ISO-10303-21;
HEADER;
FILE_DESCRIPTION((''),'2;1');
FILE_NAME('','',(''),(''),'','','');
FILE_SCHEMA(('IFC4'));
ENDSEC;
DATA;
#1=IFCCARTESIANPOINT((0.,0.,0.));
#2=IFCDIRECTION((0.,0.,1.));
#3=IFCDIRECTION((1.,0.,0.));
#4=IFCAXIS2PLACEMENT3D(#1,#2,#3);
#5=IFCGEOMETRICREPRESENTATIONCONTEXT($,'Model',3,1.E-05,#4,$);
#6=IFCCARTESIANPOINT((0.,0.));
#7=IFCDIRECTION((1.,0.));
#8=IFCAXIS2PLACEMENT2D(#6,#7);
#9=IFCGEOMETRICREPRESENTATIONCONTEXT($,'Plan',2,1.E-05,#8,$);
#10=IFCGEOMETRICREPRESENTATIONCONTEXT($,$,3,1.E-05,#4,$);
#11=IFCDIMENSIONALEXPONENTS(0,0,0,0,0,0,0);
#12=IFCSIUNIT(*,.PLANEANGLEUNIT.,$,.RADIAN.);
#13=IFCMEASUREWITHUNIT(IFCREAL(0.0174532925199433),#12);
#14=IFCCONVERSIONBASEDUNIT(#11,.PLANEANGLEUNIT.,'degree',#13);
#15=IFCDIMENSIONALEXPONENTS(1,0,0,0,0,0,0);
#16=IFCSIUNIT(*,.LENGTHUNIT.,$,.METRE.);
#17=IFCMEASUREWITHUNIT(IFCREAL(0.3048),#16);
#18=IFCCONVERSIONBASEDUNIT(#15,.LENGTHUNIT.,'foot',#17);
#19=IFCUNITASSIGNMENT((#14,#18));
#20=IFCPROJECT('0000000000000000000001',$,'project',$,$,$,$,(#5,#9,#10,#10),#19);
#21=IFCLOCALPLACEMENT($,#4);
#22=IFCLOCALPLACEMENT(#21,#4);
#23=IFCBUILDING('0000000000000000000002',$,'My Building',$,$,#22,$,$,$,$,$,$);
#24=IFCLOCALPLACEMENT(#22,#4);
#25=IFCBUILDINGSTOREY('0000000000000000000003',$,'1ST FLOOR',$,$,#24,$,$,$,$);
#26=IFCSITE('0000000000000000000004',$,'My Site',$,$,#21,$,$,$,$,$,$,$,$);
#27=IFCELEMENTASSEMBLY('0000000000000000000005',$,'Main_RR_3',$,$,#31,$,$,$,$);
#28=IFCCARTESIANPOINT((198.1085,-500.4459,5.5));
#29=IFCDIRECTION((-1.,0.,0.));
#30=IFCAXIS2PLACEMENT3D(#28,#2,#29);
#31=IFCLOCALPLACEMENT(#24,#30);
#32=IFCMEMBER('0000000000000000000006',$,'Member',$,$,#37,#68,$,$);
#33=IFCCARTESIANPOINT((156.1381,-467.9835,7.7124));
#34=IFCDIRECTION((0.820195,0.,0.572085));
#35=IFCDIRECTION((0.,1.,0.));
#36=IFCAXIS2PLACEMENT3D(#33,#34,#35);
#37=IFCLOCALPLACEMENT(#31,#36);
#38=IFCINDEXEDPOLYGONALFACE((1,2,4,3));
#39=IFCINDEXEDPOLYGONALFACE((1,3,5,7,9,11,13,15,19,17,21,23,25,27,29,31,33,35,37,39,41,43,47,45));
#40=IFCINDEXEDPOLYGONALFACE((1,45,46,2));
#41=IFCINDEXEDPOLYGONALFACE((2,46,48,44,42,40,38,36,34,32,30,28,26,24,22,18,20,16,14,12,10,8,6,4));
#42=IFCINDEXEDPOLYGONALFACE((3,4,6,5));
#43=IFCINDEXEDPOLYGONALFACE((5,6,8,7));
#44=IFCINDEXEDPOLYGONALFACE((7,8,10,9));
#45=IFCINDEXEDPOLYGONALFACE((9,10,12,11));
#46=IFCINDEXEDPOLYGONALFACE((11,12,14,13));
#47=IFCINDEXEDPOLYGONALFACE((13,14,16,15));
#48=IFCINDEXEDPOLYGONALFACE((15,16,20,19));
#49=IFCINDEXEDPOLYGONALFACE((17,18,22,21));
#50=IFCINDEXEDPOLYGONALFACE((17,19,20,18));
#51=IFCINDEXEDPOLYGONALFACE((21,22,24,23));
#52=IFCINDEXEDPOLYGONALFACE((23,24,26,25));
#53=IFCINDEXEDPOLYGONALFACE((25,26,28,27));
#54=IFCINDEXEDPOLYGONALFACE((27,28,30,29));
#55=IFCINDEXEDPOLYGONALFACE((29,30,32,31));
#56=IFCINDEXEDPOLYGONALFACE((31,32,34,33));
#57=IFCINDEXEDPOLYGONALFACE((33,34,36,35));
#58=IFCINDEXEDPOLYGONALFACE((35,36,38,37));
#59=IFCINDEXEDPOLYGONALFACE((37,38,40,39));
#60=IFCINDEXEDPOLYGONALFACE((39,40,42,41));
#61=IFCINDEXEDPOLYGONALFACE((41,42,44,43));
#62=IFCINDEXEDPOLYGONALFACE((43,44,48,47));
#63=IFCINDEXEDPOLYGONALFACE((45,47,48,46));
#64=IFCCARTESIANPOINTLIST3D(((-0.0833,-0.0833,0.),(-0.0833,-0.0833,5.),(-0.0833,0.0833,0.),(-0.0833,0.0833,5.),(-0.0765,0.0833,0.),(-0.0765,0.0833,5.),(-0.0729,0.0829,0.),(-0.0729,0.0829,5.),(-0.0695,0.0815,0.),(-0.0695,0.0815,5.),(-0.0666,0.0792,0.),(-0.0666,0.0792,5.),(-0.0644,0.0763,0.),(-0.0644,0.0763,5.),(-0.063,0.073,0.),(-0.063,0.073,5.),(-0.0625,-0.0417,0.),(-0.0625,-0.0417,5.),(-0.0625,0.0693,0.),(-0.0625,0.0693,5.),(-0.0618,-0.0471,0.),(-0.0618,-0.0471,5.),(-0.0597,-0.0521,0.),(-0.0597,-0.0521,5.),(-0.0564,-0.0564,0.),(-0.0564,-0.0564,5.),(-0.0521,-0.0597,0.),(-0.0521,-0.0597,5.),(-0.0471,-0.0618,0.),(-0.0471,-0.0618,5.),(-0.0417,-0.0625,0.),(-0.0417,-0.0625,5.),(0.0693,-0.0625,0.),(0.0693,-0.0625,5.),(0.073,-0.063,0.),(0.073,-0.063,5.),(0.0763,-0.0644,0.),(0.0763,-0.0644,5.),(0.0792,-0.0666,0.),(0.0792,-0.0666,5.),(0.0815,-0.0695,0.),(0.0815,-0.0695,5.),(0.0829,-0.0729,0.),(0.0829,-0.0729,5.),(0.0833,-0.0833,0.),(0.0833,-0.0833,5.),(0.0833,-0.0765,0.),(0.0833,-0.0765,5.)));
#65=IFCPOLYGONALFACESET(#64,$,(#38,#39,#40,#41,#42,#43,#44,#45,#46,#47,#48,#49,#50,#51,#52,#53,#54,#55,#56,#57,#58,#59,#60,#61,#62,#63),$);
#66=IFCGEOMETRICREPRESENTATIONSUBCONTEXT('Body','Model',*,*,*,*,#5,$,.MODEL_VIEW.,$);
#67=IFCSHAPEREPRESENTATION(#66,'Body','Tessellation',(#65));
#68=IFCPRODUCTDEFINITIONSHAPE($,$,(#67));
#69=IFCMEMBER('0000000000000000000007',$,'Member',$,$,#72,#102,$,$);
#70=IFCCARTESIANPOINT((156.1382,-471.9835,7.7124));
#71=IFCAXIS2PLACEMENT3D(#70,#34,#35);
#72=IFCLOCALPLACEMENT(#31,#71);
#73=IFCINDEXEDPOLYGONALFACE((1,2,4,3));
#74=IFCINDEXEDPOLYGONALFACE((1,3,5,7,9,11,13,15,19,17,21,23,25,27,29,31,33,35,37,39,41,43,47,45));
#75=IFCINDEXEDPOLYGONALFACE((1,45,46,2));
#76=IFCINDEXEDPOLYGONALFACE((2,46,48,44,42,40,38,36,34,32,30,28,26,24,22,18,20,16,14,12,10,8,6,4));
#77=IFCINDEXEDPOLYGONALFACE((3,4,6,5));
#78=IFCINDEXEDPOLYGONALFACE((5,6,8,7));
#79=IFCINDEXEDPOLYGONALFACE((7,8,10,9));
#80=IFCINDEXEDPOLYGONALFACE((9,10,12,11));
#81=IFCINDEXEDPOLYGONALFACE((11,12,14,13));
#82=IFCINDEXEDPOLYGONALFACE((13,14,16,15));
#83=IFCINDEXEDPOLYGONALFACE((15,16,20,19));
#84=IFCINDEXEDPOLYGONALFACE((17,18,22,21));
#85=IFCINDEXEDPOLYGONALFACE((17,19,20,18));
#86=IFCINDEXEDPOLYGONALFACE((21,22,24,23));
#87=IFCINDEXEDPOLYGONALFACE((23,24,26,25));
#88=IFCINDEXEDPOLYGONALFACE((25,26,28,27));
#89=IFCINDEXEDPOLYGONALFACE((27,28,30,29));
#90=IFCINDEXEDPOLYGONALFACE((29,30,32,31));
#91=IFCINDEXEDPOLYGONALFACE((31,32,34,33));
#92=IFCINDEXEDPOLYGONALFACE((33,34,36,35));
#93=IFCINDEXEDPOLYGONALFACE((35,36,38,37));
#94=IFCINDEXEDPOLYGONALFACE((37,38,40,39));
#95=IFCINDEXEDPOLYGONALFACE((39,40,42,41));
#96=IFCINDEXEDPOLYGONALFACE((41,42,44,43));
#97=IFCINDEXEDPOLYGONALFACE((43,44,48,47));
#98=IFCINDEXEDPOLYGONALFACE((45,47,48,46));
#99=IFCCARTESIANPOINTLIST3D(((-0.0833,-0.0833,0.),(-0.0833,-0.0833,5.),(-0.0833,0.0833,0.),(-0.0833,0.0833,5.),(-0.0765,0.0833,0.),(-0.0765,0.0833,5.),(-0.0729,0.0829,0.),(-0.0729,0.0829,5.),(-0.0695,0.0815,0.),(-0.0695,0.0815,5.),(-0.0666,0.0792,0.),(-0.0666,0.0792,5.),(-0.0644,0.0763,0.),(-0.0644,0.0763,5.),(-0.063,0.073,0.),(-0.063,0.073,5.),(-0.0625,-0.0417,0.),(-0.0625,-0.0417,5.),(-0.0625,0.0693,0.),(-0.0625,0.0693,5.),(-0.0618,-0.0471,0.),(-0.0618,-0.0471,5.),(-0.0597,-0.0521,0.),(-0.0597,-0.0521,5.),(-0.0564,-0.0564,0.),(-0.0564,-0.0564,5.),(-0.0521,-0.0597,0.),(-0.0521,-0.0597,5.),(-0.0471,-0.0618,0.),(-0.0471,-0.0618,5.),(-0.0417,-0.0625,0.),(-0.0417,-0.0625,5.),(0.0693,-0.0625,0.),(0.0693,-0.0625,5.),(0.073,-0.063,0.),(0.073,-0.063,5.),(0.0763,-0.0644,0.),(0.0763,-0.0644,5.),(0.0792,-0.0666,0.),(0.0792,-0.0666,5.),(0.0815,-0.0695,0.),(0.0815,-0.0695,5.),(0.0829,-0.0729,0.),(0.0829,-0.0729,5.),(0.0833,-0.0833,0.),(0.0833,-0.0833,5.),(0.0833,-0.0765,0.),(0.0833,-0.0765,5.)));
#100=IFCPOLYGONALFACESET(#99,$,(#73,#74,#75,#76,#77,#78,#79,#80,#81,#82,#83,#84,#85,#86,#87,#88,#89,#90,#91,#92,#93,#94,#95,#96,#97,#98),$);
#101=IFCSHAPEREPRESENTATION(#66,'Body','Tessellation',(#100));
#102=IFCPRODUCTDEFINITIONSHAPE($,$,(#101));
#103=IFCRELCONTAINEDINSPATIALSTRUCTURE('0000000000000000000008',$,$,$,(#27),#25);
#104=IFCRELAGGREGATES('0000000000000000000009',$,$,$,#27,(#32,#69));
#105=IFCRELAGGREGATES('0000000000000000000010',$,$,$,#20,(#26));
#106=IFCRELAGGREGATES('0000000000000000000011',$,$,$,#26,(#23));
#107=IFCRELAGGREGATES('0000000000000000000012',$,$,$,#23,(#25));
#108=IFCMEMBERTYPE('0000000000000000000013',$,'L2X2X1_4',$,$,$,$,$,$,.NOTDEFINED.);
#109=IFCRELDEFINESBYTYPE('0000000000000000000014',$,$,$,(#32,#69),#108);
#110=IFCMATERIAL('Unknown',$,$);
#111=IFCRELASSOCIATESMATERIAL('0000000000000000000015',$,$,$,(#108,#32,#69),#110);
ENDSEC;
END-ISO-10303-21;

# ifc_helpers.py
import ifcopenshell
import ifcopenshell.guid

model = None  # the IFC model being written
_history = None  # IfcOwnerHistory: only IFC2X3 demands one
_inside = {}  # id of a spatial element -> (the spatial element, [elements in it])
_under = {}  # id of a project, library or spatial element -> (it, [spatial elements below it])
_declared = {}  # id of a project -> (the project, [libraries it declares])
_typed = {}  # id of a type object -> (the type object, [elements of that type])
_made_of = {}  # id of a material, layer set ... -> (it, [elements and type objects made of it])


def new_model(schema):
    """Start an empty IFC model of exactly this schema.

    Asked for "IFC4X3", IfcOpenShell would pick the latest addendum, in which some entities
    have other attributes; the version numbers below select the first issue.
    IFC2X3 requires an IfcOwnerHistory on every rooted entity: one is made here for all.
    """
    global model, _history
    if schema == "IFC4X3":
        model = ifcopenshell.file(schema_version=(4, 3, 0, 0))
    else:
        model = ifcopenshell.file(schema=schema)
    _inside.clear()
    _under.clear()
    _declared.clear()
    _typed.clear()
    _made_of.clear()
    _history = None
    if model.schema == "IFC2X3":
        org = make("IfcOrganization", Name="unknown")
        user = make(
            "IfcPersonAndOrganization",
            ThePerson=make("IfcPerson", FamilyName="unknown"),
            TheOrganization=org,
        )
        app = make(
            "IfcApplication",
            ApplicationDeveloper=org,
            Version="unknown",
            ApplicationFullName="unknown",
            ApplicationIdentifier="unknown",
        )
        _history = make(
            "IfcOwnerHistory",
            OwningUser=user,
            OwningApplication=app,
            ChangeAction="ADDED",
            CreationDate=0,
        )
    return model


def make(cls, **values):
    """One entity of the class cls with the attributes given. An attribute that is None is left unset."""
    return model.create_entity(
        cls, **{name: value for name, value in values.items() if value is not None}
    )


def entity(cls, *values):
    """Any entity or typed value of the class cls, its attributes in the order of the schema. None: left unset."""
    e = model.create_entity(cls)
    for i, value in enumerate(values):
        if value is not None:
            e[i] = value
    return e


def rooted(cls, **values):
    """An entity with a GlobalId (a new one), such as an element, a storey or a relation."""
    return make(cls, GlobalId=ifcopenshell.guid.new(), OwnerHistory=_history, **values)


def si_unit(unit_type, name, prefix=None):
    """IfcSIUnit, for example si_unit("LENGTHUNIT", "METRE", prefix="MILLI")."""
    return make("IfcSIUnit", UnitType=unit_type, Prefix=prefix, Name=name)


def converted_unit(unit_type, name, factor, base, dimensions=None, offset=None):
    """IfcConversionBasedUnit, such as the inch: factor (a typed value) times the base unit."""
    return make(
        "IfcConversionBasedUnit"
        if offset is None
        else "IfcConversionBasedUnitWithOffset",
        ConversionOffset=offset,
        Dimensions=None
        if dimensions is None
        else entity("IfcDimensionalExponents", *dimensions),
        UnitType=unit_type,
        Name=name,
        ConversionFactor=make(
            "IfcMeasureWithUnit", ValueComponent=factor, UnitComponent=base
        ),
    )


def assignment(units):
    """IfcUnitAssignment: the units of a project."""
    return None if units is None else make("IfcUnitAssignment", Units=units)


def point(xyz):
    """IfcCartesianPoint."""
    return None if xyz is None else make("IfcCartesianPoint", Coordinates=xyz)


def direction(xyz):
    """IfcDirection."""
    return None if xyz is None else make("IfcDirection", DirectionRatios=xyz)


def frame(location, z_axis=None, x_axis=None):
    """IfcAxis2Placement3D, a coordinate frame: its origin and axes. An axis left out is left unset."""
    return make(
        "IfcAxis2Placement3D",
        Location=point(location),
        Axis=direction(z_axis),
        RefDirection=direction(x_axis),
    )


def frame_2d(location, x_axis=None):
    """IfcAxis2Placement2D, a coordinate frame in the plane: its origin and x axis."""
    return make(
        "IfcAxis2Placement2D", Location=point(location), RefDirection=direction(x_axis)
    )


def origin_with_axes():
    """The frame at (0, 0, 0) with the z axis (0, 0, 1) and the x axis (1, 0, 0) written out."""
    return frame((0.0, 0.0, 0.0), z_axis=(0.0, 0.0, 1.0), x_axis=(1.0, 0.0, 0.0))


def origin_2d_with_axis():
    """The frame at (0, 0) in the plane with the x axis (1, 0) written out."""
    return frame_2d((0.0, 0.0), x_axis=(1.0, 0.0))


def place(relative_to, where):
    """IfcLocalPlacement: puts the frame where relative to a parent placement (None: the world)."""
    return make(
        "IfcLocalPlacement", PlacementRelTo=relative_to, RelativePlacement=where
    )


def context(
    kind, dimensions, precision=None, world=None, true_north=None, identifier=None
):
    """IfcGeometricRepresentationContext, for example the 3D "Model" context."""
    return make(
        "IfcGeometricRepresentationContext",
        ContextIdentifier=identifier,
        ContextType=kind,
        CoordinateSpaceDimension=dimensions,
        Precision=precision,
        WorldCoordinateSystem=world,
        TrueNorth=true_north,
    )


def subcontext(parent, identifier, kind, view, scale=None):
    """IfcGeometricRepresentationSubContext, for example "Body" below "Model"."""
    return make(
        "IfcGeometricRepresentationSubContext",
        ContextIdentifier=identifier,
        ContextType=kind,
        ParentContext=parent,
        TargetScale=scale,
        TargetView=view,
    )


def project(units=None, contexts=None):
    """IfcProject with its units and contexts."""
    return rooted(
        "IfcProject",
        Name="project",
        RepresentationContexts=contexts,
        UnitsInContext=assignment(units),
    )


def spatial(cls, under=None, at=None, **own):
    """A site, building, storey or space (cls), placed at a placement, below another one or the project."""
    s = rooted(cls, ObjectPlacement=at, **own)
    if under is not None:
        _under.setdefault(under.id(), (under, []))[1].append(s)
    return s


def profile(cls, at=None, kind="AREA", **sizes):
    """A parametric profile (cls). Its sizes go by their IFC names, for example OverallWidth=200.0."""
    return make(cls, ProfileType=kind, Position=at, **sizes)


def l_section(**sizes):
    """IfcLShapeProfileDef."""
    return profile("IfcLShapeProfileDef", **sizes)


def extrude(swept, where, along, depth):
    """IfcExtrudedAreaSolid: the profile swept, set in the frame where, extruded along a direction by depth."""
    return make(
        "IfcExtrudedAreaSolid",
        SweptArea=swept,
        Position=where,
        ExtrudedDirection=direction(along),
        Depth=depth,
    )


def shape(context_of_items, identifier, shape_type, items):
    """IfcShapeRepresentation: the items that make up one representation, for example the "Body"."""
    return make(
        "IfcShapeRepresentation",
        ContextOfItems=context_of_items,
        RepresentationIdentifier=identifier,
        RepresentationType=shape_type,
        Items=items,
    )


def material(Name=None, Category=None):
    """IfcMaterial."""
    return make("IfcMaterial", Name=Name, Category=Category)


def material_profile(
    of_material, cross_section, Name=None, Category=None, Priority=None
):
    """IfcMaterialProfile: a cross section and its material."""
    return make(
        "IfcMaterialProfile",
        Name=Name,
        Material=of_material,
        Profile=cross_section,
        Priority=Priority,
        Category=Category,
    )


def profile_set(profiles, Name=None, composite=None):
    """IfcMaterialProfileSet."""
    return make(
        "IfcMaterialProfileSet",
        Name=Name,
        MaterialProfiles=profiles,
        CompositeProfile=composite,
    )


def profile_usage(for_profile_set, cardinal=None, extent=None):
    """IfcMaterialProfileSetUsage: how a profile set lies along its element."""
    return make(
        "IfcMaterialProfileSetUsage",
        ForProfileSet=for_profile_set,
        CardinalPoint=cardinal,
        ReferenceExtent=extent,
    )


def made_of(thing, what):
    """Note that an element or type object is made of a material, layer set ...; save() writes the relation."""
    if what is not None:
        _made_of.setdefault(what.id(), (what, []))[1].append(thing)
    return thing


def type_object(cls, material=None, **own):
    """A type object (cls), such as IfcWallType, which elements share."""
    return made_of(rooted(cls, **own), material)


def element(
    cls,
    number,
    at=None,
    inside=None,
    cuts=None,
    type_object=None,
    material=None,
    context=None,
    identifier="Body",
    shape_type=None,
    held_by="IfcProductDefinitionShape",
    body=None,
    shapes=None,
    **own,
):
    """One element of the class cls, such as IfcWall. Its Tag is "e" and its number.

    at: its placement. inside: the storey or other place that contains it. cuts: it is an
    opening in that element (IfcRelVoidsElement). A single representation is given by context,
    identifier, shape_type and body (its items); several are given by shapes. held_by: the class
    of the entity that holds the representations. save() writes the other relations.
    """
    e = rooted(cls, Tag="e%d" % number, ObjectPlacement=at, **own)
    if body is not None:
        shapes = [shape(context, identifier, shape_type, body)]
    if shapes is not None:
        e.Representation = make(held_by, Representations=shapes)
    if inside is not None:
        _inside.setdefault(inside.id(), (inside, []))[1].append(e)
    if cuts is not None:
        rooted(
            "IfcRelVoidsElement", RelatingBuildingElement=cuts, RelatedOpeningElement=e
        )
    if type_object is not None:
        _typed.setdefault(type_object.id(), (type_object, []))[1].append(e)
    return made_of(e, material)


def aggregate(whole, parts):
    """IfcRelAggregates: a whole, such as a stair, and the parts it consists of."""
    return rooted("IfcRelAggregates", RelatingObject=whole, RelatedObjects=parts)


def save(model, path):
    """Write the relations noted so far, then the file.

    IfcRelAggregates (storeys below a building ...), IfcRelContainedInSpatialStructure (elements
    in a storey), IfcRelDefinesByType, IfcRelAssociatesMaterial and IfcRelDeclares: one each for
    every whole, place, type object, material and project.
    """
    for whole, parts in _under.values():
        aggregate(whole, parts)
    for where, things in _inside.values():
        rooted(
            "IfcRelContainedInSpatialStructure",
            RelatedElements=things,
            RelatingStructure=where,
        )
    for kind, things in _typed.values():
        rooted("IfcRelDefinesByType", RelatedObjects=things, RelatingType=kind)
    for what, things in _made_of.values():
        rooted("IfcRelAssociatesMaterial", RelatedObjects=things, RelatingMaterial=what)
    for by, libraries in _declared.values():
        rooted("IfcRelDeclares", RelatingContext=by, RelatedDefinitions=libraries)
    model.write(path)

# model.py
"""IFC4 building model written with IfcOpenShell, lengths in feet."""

from ifc_helpers import new_model, entity, si_unit, converted_unit, frame, origin_with_axes, origin_2d_with_axis, place, context, subcontext, project, spatial, l_section, extrude, material, material_profile, profile_set, profile_usage, type_object, element, aggregate, save


model = new_model("IFC4")

# Units and contexts
model_context = context("Model", 3, precision=1e-05, world=origin_with_axes())
plan_context = context("Plan", 2, precision=1e-05, world=origin_2d_with_axis())
context_of_model = context(None, 3, precision=1e-05, world=origin_with_axes())
body_context_1 = subcontext(model_context, "Body", "Model", "MODEL_VIEW")
ifc_project = project(units=[converted_unit("PLANEANGLEUNIT", "degree", entity("IfcReal", 0.0174532925199433), si_unit("PLANEANGLEUNIT", "RADIAN"), dimensions=[0, 0, 0, 0, 0, 0, 0]), converted_unit("LENGTHUNIT", "foot", entity("IfcReal", 0.3048), si_unit("LENGTHUNIT", "METRE"), dimensions=[1, 0, 0, 0, 0, 0, 0])], contexts=[model_context, plan_context, context_of_model, context_of_model])

# Site, building, storey
site_placement = place(None, origin_with_axes())
site = spatial("IfcSite", under=ifc_project, at=site_placement, Name="My Site")
building_placement = place(site_placement, origin_with_axes())
building = spatial("IfcBuilding", under=site, at=building_placement, Name="My Building")
storey_placement = place(building_placement, origin_with_axes())
storey = spatial("IfcBuildingStorey", under=building, at=storey_placement, Name="1ST FLOOR")

# Element assembly, members
assembly_placement = place(storey_placement, frame((198.1085, -500.4459, 5.5), z_axis=(0.0, 0.0, 1.0), x_axis=(-1.0, 0.0, 0.0)))
assembly = element("IfcElementAssembly", 1, at=assembly_placement, inside=storey, Name="Main_RR_3")
ifc_material_1 = material(Name="Unknown")
ifc_material_profile_1 = material_profile(ifc_material_1, l_section(Depth=0.1667, Width=0.1667, Thickness=0.0208, FilletRadius=0.0208, EdgeRadius=0.014))
ifc_profile_set_1 = profile_set([ifc_material_profile_1])
ifc_profile_usage_1 = profile_usage(ifc_profile_set_1, cardinal=5)
member_type = type_object("IfcMemberType", Name="L2X2X1_4", PredefinedType="NOTDEFINED", material=ifc_profile_set_1)
member_1_placement = place(assembly_placement, frame((156.1381, -467.9835, 7.7124), z_axis=(0.820195, 0.0, 0.572085), x_axis=(0.0, 1.0, 0.0)))
member_1 = element("IfcMember", 2, at=member_1_placement, type_object=member_type, material=ifc_profile_usage_1, Name="Member", context=body_context_1, shape_type="SweptSolid", body=[
    extrude(l_section(Depth=0.1667, Width=0.1667, Thickness=0.0208, FilletRadius=0.0208, EdgeRadius=0.014), origin_with_axes(), (0.0, 0.0, 1.0), 5.0),
])
ifc_profile_usage_2 = profile_usage(ifc_profile_set_1, cardinal=5)
member_2_placement = place(assembly_placement, frame((156.1382, -471.9835, 7.7124), z_axis=(0.820195, 0.0, 0.572085), x_axis=(0.0, 1.0, 0.0)))
member_2 = element("IfcMember", 3, at=member_2_placement, type_object=member_type, material=ifc_profile_usage_2, Name="Member", context=body_context_1, shape_type="SweptSolid", body=[
    extrude(l_section(Depth=0.1667, Width=0.1667, Thickness=0.0208, FilletRadius=0.0208, EdgeRadius=0.014), origin_with_axes(), (0.0, 0.0, 1.0), 5.0),
])
aggregate(assembly, [member_1, member_2])

save(model, "model.ifc")
